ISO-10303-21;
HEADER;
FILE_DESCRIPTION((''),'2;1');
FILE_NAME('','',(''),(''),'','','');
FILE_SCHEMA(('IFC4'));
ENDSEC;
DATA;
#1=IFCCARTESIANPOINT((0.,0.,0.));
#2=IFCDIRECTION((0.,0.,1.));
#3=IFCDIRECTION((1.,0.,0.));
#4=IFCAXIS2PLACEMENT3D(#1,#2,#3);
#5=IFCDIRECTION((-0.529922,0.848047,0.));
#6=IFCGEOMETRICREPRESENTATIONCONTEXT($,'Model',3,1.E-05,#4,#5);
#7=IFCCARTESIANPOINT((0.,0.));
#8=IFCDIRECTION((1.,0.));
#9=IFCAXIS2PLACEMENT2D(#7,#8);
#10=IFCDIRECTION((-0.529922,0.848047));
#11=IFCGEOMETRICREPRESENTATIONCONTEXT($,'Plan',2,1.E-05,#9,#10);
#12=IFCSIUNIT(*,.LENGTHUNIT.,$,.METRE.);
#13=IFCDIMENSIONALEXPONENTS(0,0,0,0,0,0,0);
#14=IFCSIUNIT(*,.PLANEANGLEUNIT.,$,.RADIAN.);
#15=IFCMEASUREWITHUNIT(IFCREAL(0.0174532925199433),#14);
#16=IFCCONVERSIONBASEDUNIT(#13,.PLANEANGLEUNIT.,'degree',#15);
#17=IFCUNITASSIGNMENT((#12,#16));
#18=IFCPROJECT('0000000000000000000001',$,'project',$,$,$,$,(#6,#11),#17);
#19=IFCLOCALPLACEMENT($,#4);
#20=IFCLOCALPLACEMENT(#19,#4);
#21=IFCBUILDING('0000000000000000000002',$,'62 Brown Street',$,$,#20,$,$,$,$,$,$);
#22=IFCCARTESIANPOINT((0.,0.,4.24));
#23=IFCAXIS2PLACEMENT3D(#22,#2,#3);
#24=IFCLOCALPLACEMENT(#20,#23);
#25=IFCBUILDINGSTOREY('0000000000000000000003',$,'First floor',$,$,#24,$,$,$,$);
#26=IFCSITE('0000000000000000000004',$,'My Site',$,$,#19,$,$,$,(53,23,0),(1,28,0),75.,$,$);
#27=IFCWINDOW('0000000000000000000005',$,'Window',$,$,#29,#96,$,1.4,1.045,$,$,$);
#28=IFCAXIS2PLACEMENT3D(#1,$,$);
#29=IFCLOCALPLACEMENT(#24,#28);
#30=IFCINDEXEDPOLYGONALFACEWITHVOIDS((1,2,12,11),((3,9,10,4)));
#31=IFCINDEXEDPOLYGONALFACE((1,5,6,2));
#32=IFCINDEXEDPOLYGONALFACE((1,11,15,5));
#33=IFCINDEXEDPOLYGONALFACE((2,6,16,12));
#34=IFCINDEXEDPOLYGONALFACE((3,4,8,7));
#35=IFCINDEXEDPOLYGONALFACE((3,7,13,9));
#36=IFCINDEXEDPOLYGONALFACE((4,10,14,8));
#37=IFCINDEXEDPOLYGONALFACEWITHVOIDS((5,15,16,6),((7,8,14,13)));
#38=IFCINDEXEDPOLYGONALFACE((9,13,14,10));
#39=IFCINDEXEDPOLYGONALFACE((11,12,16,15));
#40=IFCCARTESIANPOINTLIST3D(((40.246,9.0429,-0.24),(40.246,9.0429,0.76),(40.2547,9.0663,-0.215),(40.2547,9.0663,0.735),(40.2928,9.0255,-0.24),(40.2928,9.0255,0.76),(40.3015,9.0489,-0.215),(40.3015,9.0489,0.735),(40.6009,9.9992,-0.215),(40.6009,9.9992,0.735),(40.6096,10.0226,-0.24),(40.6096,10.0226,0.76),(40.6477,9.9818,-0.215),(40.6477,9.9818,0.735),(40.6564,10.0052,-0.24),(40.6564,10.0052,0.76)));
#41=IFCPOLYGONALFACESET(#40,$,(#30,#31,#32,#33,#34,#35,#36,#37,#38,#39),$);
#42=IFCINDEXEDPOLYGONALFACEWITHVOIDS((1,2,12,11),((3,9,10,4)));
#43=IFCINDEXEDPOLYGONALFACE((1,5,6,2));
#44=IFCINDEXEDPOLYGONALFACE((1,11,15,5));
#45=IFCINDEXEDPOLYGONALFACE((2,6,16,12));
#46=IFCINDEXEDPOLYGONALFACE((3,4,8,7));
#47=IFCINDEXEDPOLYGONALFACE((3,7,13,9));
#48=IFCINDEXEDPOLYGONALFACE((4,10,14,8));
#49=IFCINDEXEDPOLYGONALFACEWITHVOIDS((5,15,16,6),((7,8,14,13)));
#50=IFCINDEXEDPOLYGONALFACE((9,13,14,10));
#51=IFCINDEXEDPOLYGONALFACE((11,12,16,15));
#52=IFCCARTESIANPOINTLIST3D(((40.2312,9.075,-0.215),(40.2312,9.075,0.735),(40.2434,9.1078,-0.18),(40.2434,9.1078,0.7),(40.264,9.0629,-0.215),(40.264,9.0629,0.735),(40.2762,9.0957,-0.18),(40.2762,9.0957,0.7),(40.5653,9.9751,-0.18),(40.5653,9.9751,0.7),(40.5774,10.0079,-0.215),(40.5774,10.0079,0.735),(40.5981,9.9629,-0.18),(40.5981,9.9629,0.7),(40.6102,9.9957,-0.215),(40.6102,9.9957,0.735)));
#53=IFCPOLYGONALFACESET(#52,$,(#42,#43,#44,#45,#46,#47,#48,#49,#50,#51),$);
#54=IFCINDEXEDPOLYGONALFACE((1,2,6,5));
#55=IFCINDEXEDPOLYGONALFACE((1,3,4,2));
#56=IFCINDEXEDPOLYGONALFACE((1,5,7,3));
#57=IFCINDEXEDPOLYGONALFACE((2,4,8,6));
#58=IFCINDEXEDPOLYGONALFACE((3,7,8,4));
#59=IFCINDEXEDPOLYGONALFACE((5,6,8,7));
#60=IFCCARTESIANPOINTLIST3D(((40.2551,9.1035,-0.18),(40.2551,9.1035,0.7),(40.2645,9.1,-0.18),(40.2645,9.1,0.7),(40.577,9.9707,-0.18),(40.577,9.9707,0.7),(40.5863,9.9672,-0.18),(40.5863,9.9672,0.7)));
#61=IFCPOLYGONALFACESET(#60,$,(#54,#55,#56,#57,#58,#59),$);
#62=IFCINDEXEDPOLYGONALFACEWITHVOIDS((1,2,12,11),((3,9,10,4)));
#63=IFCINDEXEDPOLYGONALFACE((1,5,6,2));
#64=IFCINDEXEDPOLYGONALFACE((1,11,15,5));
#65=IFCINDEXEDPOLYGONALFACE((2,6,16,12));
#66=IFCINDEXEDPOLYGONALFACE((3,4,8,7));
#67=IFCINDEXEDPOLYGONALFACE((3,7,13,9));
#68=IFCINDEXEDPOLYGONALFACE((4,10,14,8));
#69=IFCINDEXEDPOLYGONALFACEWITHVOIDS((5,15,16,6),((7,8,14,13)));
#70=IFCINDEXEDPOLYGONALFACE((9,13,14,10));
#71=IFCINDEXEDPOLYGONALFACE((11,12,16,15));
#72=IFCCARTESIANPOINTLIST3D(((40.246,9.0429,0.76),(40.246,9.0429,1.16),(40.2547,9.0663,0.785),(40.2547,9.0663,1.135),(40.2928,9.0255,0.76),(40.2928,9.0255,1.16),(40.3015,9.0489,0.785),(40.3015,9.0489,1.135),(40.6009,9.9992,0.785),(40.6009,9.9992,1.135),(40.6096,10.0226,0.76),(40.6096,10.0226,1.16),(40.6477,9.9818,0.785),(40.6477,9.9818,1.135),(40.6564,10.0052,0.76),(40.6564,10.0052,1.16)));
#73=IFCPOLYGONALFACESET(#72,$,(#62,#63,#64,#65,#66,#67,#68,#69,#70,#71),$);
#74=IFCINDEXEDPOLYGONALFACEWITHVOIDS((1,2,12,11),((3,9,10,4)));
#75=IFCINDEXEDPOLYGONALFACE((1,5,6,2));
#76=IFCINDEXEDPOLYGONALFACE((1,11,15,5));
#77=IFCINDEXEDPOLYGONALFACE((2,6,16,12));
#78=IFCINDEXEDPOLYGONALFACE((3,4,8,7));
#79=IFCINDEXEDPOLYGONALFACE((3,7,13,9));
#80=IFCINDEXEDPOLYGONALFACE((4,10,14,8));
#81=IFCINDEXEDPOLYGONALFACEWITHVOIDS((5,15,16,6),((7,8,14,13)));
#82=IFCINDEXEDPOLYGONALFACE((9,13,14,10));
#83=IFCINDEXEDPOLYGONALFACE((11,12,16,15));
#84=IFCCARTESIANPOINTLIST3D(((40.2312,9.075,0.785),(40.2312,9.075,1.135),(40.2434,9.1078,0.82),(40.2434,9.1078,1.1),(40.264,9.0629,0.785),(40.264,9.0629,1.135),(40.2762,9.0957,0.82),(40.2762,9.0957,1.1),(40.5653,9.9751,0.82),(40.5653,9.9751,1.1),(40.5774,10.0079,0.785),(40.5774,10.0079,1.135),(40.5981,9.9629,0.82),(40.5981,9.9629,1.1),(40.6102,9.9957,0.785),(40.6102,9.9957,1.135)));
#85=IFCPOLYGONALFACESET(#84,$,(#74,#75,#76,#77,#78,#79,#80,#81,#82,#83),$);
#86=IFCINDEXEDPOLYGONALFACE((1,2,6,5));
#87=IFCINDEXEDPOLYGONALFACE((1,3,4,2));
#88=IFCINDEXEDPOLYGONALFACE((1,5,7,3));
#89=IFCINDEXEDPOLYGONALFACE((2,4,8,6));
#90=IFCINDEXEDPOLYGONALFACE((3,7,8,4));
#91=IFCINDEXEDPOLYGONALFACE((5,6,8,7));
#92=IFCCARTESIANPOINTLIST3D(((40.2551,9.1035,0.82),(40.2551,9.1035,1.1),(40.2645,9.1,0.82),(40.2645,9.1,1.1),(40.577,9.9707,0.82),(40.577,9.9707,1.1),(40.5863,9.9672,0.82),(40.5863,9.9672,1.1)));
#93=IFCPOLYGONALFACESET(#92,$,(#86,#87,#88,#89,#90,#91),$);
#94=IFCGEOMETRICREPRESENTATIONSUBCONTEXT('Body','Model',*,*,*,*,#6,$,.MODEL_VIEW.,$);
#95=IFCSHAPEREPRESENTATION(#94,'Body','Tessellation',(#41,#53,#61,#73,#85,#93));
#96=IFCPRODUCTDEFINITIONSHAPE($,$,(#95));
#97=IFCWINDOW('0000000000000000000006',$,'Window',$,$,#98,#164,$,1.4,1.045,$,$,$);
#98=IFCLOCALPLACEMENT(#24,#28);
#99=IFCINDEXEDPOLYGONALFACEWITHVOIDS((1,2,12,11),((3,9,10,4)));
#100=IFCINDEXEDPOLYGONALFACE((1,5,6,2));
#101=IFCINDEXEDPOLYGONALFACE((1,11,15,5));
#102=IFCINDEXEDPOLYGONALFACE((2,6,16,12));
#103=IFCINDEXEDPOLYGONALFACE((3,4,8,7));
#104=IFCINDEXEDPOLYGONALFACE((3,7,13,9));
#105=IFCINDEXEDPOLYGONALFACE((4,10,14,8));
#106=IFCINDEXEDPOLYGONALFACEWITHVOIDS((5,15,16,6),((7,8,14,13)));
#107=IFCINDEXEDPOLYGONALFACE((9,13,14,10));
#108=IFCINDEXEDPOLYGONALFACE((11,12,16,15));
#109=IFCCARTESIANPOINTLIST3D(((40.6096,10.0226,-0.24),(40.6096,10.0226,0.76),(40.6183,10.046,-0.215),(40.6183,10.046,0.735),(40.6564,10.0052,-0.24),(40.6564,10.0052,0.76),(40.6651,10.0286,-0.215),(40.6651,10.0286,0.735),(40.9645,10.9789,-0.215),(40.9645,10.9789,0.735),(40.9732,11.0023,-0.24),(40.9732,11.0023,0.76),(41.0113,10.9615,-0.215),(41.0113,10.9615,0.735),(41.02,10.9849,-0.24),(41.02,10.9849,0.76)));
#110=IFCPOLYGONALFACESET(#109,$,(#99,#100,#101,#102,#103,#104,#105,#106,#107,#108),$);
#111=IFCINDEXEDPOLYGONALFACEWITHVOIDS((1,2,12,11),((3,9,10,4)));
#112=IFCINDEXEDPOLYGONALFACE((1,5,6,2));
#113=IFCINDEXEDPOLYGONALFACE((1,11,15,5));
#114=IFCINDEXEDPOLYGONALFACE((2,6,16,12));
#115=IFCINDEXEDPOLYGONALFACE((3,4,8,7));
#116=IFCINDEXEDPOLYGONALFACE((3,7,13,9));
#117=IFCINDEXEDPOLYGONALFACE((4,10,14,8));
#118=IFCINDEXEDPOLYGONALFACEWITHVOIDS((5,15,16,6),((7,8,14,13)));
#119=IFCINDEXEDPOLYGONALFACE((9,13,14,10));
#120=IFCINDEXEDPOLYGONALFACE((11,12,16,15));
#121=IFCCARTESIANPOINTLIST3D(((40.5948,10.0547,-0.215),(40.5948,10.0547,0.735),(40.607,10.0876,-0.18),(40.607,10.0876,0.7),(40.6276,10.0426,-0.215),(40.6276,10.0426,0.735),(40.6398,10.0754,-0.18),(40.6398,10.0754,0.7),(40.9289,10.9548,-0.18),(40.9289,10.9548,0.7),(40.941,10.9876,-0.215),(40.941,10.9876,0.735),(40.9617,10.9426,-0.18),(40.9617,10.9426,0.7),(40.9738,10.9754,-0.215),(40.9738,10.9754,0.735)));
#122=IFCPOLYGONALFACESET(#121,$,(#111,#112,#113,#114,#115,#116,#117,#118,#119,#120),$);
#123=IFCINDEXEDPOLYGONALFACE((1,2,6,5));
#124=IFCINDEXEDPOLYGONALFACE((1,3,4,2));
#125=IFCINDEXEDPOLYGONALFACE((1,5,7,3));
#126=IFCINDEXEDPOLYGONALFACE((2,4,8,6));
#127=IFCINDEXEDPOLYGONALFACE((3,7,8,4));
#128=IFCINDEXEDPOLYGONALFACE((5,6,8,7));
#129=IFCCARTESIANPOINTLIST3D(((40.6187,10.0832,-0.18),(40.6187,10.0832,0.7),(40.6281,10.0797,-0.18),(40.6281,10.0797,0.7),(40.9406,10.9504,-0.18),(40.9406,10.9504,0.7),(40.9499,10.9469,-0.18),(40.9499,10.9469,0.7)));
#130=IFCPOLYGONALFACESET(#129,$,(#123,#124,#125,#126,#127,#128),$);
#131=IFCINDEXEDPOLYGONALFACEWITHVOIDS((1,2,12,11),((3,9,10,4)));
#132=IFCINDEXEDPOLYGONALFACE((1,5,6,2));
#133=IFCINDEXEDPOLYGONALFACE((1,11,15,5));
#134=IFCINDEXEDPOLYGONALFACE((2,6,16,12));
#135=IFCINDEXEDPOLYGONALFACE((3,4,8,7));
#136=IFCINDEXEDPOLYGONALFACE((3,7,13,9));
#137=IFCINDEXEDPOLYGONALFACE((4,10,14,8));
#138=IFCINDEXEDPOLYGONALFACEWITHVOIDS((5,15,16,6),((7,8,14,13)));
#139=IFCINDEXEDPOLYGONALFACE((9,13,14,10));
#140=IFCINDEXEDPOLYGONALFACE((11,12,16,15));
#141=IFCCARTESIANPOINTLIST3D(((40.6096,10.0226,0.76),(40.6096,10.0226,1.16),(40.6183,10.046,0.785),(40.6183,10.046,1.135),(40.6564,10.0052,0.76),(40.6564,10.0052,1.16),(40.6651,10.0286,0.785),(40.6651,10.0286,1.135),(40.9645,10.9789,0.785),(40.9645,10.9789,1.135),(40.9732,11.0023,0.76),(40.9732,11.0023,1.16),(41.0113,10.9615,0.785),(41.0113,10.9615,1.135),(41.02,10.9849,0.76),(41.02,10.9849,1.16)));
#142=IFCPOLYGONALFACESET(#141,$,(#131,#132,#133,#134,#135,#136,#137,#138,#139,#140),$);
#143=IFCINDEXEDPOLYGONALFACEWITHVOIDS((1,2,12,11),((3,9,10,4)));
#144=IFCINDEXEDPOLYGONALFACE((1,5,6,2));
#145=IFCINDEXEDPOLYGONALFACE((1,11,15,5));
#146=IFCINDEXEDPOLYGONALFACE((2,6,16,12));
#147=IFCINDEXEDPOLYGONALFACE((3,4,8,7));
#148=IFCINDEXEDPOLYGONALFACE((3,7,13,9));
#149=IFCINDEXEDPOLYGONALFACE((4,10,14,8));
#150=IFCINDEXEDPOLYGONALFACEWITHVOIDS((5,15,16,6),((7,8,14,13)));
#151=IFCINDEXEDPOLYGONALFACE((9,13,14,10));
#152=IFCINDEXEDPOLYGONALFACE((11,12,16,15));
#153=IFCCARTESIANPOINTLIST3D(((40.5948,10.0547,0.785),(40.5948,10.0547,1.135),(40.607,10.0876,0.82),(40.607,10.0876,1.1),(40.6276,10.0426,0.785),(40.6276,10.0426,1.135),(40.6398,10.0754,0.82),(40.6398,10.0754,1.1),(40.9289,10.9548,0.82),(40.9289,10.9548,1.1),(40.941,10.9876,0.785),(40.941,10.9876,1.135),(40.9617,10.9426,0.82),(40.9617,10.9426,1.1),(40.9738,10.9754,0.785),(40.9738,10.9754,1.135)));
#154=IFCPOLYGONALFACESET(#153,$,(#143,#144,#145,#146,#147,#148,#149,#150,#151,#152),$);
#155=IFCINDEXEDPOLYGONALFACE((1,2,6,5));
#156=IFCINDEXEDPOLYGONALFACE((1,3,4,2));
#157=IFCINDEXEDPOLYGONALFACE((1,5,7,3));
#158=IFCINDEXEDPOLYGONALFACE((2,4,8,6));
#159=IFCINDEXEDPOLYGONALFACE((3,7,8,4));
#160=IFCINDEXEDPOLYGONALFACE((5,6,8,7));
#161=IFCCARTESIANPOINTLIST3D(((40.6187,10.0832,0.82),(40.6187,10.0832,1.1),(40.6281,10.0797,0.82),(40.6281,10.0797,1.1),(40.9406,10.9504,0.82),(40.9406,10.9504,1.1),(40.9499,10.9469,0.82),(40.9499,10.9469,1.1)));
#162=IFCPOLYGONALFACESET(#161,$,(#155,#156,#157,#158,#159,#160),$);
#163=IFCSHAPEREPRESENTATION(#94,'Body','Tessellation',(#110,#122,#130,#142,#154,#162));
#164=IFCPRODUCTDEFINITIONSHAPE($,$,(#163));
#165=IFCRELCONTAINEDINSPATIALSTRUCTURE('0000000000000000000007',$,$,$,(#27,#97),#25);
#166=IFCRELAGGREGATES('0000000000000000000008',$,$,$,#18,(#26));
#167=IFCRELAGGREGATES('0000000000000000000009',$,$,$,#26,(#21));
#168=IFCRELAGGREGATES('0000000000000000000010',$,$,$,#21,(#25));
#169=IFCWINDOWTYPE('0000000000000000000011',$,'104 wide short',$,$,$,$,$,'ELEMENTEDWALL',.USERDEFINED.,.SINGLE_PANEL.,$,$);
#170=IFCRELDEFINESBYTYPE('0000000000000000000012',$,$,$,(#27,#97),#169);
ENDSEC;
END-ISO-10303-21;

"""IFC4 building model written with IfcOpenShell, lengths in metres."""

from ifc_helpers import new_model, entity, si_unit, converted_unit, direction, frame, origin_with_axes, origin_2d_with_axis, place, context, subcontext, project, spatial, line, indexed_curve, outline, extrude, shape, source, transform, mapped, type_object, type_shapes, element, save


model = new_model("IFC4")

# Units and contexts
model_context = context("Model", 3, precision=1e-05, world=origin_with_axes(), true_north=direction((-0.529922, 0.848047, 0.0)))
plan_context = context("Plan", 2, precision=1e-05, world=origin_2d_with_axis(), true_north=direction((-0.529922, 0.848047)))
body_context_1 = subcontext(model_context, "Body", "Model", "MODEL_VIEW")
body_context_2 = subcontext(plan_context, "Body", "Plan", "PLAN_VIEW")
ifc_project = project(units=[si_unit("LENGTHUNIT", "METRE"), converted_unit("PLANEANGLEUNIT", "degree", entity("IfcReal", 0.0174532925199433), si_unit("PLANEANGLEUNIT", "RADIAN"), dimensions=[0, 0, 0, 0, 0, 0, 0])], contexts=[model_context, plan_context])

# Site, building, storey
site_placement = place(None, origin_with_axes())
site = spatial("IfcSite", under=ifc_project, at=site_placement, Name="My Site", RefLatitude=(53, 23, 0), RefLongitude=(1, 28, 0), RefElevation=75.0)
building_placement = place(site_placement, origin_with_axes())
building = spatial("IfcBuilding", under=site, at=building_placement, Name="62 Brown Street")
storey_placement = place(building_placement, frame((0.0, 0.0, 4.24), z_axis=(0.0, 0.0, 1.0), x_axis=(1.0, 0.0, 0.0)))
storey = spatial("IfcBuildingStorey", under=building, at=storey_placement, Name="First floor")

# Shared definitions
window_type = type_object("IfcWindowType", Name="104 wide short", ElementType="ELEMENTEDWALL", PartitioningType="SINGLE_PANEL", PredefinedType="USERDEFINED")
shared_shape_1 = source(origin_with_axes(), body_context_1, "Body", "SweptSolid", [
    extrude(outline(indexed_curve([(0.0, 0.0), (1.045, 0.0), (1.045, 1.0), (0.0, 1.0)], segments=[line(1, 2, 3, 4, 1)]), holes=[indexed_curve([(0.025, 0.025), (1.02, 0.025), (1.02, 0.975), (0.025, 0.975)], segments=[line(1, 2, 3, 4, 1)])]), frame((0.0, 0.15, 0.0), z_axis=(0.0, -1.0, 0.0), x_axis=(1.0, 0.0, 0.0)), (0.0, 0.0, -1.0), 0.05),
    extrude(outline(indexed_curve([(0.0, 0.0), (0.995, 0.0), (0.995, 0.95), (0.0, 0.95)], segments=[line(1, 2, 3, 4, 1)]), holes=[indexed_curve([(0.035, 0.035), (0.96, 0.035), (0.96, 0.915), (0.035, 0.915)], segments=[line(1, 2, 3, 4, 1)])]), frame((0.025, 0.19, 0.025), z_axis=(0.0, -1.0, 0.0), x_axis=(1.0, 0.0, 0.0)), (0.0, 0.0, -1.0), 0.035),
    extrude(outline(indexed_curve([(0.035, 0.035), (0.96, 0.035), (0.96, 0.915), (0.035, 0.915)], segments=[line(1, 2, 3, 4, 1)])), frame((0.025, 0.2025, 0.025), z_axis=(0.0, -1.0, 0.0), x_axis=(1.0, 0.0, 0.0)), (0.0, 0.0, -1.0), 0.01),
    extrude(outline(indexed_curve([(0.0, 0.0), (1.045, 0.0), (1.045, 0.4), (0.0, 0.4)], segments=[line(1, 2, 3, 4, 1)]), holes=[indexed_curve([(0.025, 0.025), (1.02, 0.025), (1.02, 0.375), (0.025, 0.375)], segments=[line(1, 2, 3, 4, 1)])]), frame((0.0, 0.15, 1.0), z_axis=(0.0, -1.0, 0.0), x_axis=(1.0, 0.0, 0.0)), (0.0, 0.0, -1.0), 0.05),
    extrude(outline(indexed_curve([(0.0, 0.0), (0.995, 0.0), (0.995, 0.35), (0.0, 0.35)], segments=[line(1, 2, 3, 4, 1)]), holes=[indexed_curve([(0.035, 0.035), (0.96, 0.035), (0.96, 0.315), (0.035, 0.315)], segments=[line(1, 2, 3, 4, 1)])]), frame((0.025, 0.19, 1.025), z_axis=(0.0, -1.0, 0.0), x_axis=(1.0, 0.0, 0.0)), (0.0, 0.0, -1.0), 0.035),
    extrude(outline(indexed_curve([(0.035, 0.035), (0.96, 0.035), (0.96, 0.315), (0.035, 0.315)], segments=[line(1, 2, 3, 4, 1)])), frame((0.025, 0.2025, 1.025), z_axis=(0.0, -1.0, 0.0), x_axis=(1.0, 0.0, 0.0)), (0.0, 0.0, -1.0), 0.01),
])
shared_shape_2 = source(origin_with_axes(), body_context_2, "Body", "Curve2D", [
    entity("IfcIndexedPolyCurve", entity("IfcCartesianPointList2D", [[0.025, 0.15], [1.02, 0.15]])),
    entity("IfcIndexedPolyCurve", entity("IfcCartesianPointList2D", [[0.0, 0.2], [0.025, 0.2], [0.025, 0.15], [0.0, 0.15]]), [entity("IfcLineIndex", [1, 2, 3, 4, 1])]),
    entity("IfcIndexedPolyCurve", entity("IfcCartesianPointList2D", [[1.045, 0.2], [1.02, 0.2], [1.02, 0.15], [1.045, 0.15]]), [entity("IfcLineIndex", [1, 2, 3, 4, 1])]),
    entity("IfcIndexedPolyCurve", entity("IfcCartesianPointList2D", [[0.025, 0.19], [0.06, 0.19], [0.06, 0.225], [0.025, 0.225]]), [entity("IfcLineIndex", [1, 2, 3, 4, 1])]),
    entity("IfcIndexedPolyCurve", entity("IfcCartesianPointList2D", [[1.02, 0.19], [0.985, 0.19], [0.985, 0.225], [1.02, 0.225]]), [entity("IfcLineIndex", [1, 2, 3, 4, 1])]),
    entity("IfcIndexedPolyCurve", entity("IfcCartesianPointList2D", [[0.06, 0.19], [0.985, 0.19]])),
    entity("IfcIndexedPolyCurve", entity("IfcCartesianPointList2D", [[0.06, 0.225], [0.985, 0.225]])),
    entity("IfcIndexedPolyCurve", entity("IfcCartesianPointList2D", [[0.06, 0.2075], [0.985, 0.2075]])),
])
type_shapes(window_type, [shared_shape_1, shared_shape_2])

# Windows
for number, where, z_axis, x_axis, name in (
    (1, (40.4335, 8.9733, -0.24), (0.0, 0.0, 1.0), (0.347944, 0.937515, 0.0), "Window"),
    (2, (40.7971, 9.953, -0.24), (0.0, 0.0, 1.0), (0.347944, 0.937515, 0.0), "Window"),
):
    element("IfcWindow", number, at=place(storey_placement, frame(where, z_axis=z_axis, x_axis=x_axis)), inside=storey, type_object=window_type, Name=name, OverallHeight=1.4, OverallWidth=1.045, shapes=[
        shape(body_context_1, "Body", "MappedRepresentation", [mapped(shared_shape_1, transform((0.0, 0.0, 0.0), x_axis=(1.0, 0.0, 0.0), y_axis=(0.0, 1.0, 0.0), z_axis=(0.0, 0.0, 1.0), scale=1.0))]),
        shape(body_context_2, "Body", "MappedRepresentation", [mapped(shared_shape_2, transform((0.0, 0.0, 0.0), x_axis=(1.0, 0.0, 0.0), y_axis=(0.0, 1.0, 0.0), z_axis=(0.0, 0.0, 1.0), scale=1.0))]),
    ])

save(model, "model.ifc")
